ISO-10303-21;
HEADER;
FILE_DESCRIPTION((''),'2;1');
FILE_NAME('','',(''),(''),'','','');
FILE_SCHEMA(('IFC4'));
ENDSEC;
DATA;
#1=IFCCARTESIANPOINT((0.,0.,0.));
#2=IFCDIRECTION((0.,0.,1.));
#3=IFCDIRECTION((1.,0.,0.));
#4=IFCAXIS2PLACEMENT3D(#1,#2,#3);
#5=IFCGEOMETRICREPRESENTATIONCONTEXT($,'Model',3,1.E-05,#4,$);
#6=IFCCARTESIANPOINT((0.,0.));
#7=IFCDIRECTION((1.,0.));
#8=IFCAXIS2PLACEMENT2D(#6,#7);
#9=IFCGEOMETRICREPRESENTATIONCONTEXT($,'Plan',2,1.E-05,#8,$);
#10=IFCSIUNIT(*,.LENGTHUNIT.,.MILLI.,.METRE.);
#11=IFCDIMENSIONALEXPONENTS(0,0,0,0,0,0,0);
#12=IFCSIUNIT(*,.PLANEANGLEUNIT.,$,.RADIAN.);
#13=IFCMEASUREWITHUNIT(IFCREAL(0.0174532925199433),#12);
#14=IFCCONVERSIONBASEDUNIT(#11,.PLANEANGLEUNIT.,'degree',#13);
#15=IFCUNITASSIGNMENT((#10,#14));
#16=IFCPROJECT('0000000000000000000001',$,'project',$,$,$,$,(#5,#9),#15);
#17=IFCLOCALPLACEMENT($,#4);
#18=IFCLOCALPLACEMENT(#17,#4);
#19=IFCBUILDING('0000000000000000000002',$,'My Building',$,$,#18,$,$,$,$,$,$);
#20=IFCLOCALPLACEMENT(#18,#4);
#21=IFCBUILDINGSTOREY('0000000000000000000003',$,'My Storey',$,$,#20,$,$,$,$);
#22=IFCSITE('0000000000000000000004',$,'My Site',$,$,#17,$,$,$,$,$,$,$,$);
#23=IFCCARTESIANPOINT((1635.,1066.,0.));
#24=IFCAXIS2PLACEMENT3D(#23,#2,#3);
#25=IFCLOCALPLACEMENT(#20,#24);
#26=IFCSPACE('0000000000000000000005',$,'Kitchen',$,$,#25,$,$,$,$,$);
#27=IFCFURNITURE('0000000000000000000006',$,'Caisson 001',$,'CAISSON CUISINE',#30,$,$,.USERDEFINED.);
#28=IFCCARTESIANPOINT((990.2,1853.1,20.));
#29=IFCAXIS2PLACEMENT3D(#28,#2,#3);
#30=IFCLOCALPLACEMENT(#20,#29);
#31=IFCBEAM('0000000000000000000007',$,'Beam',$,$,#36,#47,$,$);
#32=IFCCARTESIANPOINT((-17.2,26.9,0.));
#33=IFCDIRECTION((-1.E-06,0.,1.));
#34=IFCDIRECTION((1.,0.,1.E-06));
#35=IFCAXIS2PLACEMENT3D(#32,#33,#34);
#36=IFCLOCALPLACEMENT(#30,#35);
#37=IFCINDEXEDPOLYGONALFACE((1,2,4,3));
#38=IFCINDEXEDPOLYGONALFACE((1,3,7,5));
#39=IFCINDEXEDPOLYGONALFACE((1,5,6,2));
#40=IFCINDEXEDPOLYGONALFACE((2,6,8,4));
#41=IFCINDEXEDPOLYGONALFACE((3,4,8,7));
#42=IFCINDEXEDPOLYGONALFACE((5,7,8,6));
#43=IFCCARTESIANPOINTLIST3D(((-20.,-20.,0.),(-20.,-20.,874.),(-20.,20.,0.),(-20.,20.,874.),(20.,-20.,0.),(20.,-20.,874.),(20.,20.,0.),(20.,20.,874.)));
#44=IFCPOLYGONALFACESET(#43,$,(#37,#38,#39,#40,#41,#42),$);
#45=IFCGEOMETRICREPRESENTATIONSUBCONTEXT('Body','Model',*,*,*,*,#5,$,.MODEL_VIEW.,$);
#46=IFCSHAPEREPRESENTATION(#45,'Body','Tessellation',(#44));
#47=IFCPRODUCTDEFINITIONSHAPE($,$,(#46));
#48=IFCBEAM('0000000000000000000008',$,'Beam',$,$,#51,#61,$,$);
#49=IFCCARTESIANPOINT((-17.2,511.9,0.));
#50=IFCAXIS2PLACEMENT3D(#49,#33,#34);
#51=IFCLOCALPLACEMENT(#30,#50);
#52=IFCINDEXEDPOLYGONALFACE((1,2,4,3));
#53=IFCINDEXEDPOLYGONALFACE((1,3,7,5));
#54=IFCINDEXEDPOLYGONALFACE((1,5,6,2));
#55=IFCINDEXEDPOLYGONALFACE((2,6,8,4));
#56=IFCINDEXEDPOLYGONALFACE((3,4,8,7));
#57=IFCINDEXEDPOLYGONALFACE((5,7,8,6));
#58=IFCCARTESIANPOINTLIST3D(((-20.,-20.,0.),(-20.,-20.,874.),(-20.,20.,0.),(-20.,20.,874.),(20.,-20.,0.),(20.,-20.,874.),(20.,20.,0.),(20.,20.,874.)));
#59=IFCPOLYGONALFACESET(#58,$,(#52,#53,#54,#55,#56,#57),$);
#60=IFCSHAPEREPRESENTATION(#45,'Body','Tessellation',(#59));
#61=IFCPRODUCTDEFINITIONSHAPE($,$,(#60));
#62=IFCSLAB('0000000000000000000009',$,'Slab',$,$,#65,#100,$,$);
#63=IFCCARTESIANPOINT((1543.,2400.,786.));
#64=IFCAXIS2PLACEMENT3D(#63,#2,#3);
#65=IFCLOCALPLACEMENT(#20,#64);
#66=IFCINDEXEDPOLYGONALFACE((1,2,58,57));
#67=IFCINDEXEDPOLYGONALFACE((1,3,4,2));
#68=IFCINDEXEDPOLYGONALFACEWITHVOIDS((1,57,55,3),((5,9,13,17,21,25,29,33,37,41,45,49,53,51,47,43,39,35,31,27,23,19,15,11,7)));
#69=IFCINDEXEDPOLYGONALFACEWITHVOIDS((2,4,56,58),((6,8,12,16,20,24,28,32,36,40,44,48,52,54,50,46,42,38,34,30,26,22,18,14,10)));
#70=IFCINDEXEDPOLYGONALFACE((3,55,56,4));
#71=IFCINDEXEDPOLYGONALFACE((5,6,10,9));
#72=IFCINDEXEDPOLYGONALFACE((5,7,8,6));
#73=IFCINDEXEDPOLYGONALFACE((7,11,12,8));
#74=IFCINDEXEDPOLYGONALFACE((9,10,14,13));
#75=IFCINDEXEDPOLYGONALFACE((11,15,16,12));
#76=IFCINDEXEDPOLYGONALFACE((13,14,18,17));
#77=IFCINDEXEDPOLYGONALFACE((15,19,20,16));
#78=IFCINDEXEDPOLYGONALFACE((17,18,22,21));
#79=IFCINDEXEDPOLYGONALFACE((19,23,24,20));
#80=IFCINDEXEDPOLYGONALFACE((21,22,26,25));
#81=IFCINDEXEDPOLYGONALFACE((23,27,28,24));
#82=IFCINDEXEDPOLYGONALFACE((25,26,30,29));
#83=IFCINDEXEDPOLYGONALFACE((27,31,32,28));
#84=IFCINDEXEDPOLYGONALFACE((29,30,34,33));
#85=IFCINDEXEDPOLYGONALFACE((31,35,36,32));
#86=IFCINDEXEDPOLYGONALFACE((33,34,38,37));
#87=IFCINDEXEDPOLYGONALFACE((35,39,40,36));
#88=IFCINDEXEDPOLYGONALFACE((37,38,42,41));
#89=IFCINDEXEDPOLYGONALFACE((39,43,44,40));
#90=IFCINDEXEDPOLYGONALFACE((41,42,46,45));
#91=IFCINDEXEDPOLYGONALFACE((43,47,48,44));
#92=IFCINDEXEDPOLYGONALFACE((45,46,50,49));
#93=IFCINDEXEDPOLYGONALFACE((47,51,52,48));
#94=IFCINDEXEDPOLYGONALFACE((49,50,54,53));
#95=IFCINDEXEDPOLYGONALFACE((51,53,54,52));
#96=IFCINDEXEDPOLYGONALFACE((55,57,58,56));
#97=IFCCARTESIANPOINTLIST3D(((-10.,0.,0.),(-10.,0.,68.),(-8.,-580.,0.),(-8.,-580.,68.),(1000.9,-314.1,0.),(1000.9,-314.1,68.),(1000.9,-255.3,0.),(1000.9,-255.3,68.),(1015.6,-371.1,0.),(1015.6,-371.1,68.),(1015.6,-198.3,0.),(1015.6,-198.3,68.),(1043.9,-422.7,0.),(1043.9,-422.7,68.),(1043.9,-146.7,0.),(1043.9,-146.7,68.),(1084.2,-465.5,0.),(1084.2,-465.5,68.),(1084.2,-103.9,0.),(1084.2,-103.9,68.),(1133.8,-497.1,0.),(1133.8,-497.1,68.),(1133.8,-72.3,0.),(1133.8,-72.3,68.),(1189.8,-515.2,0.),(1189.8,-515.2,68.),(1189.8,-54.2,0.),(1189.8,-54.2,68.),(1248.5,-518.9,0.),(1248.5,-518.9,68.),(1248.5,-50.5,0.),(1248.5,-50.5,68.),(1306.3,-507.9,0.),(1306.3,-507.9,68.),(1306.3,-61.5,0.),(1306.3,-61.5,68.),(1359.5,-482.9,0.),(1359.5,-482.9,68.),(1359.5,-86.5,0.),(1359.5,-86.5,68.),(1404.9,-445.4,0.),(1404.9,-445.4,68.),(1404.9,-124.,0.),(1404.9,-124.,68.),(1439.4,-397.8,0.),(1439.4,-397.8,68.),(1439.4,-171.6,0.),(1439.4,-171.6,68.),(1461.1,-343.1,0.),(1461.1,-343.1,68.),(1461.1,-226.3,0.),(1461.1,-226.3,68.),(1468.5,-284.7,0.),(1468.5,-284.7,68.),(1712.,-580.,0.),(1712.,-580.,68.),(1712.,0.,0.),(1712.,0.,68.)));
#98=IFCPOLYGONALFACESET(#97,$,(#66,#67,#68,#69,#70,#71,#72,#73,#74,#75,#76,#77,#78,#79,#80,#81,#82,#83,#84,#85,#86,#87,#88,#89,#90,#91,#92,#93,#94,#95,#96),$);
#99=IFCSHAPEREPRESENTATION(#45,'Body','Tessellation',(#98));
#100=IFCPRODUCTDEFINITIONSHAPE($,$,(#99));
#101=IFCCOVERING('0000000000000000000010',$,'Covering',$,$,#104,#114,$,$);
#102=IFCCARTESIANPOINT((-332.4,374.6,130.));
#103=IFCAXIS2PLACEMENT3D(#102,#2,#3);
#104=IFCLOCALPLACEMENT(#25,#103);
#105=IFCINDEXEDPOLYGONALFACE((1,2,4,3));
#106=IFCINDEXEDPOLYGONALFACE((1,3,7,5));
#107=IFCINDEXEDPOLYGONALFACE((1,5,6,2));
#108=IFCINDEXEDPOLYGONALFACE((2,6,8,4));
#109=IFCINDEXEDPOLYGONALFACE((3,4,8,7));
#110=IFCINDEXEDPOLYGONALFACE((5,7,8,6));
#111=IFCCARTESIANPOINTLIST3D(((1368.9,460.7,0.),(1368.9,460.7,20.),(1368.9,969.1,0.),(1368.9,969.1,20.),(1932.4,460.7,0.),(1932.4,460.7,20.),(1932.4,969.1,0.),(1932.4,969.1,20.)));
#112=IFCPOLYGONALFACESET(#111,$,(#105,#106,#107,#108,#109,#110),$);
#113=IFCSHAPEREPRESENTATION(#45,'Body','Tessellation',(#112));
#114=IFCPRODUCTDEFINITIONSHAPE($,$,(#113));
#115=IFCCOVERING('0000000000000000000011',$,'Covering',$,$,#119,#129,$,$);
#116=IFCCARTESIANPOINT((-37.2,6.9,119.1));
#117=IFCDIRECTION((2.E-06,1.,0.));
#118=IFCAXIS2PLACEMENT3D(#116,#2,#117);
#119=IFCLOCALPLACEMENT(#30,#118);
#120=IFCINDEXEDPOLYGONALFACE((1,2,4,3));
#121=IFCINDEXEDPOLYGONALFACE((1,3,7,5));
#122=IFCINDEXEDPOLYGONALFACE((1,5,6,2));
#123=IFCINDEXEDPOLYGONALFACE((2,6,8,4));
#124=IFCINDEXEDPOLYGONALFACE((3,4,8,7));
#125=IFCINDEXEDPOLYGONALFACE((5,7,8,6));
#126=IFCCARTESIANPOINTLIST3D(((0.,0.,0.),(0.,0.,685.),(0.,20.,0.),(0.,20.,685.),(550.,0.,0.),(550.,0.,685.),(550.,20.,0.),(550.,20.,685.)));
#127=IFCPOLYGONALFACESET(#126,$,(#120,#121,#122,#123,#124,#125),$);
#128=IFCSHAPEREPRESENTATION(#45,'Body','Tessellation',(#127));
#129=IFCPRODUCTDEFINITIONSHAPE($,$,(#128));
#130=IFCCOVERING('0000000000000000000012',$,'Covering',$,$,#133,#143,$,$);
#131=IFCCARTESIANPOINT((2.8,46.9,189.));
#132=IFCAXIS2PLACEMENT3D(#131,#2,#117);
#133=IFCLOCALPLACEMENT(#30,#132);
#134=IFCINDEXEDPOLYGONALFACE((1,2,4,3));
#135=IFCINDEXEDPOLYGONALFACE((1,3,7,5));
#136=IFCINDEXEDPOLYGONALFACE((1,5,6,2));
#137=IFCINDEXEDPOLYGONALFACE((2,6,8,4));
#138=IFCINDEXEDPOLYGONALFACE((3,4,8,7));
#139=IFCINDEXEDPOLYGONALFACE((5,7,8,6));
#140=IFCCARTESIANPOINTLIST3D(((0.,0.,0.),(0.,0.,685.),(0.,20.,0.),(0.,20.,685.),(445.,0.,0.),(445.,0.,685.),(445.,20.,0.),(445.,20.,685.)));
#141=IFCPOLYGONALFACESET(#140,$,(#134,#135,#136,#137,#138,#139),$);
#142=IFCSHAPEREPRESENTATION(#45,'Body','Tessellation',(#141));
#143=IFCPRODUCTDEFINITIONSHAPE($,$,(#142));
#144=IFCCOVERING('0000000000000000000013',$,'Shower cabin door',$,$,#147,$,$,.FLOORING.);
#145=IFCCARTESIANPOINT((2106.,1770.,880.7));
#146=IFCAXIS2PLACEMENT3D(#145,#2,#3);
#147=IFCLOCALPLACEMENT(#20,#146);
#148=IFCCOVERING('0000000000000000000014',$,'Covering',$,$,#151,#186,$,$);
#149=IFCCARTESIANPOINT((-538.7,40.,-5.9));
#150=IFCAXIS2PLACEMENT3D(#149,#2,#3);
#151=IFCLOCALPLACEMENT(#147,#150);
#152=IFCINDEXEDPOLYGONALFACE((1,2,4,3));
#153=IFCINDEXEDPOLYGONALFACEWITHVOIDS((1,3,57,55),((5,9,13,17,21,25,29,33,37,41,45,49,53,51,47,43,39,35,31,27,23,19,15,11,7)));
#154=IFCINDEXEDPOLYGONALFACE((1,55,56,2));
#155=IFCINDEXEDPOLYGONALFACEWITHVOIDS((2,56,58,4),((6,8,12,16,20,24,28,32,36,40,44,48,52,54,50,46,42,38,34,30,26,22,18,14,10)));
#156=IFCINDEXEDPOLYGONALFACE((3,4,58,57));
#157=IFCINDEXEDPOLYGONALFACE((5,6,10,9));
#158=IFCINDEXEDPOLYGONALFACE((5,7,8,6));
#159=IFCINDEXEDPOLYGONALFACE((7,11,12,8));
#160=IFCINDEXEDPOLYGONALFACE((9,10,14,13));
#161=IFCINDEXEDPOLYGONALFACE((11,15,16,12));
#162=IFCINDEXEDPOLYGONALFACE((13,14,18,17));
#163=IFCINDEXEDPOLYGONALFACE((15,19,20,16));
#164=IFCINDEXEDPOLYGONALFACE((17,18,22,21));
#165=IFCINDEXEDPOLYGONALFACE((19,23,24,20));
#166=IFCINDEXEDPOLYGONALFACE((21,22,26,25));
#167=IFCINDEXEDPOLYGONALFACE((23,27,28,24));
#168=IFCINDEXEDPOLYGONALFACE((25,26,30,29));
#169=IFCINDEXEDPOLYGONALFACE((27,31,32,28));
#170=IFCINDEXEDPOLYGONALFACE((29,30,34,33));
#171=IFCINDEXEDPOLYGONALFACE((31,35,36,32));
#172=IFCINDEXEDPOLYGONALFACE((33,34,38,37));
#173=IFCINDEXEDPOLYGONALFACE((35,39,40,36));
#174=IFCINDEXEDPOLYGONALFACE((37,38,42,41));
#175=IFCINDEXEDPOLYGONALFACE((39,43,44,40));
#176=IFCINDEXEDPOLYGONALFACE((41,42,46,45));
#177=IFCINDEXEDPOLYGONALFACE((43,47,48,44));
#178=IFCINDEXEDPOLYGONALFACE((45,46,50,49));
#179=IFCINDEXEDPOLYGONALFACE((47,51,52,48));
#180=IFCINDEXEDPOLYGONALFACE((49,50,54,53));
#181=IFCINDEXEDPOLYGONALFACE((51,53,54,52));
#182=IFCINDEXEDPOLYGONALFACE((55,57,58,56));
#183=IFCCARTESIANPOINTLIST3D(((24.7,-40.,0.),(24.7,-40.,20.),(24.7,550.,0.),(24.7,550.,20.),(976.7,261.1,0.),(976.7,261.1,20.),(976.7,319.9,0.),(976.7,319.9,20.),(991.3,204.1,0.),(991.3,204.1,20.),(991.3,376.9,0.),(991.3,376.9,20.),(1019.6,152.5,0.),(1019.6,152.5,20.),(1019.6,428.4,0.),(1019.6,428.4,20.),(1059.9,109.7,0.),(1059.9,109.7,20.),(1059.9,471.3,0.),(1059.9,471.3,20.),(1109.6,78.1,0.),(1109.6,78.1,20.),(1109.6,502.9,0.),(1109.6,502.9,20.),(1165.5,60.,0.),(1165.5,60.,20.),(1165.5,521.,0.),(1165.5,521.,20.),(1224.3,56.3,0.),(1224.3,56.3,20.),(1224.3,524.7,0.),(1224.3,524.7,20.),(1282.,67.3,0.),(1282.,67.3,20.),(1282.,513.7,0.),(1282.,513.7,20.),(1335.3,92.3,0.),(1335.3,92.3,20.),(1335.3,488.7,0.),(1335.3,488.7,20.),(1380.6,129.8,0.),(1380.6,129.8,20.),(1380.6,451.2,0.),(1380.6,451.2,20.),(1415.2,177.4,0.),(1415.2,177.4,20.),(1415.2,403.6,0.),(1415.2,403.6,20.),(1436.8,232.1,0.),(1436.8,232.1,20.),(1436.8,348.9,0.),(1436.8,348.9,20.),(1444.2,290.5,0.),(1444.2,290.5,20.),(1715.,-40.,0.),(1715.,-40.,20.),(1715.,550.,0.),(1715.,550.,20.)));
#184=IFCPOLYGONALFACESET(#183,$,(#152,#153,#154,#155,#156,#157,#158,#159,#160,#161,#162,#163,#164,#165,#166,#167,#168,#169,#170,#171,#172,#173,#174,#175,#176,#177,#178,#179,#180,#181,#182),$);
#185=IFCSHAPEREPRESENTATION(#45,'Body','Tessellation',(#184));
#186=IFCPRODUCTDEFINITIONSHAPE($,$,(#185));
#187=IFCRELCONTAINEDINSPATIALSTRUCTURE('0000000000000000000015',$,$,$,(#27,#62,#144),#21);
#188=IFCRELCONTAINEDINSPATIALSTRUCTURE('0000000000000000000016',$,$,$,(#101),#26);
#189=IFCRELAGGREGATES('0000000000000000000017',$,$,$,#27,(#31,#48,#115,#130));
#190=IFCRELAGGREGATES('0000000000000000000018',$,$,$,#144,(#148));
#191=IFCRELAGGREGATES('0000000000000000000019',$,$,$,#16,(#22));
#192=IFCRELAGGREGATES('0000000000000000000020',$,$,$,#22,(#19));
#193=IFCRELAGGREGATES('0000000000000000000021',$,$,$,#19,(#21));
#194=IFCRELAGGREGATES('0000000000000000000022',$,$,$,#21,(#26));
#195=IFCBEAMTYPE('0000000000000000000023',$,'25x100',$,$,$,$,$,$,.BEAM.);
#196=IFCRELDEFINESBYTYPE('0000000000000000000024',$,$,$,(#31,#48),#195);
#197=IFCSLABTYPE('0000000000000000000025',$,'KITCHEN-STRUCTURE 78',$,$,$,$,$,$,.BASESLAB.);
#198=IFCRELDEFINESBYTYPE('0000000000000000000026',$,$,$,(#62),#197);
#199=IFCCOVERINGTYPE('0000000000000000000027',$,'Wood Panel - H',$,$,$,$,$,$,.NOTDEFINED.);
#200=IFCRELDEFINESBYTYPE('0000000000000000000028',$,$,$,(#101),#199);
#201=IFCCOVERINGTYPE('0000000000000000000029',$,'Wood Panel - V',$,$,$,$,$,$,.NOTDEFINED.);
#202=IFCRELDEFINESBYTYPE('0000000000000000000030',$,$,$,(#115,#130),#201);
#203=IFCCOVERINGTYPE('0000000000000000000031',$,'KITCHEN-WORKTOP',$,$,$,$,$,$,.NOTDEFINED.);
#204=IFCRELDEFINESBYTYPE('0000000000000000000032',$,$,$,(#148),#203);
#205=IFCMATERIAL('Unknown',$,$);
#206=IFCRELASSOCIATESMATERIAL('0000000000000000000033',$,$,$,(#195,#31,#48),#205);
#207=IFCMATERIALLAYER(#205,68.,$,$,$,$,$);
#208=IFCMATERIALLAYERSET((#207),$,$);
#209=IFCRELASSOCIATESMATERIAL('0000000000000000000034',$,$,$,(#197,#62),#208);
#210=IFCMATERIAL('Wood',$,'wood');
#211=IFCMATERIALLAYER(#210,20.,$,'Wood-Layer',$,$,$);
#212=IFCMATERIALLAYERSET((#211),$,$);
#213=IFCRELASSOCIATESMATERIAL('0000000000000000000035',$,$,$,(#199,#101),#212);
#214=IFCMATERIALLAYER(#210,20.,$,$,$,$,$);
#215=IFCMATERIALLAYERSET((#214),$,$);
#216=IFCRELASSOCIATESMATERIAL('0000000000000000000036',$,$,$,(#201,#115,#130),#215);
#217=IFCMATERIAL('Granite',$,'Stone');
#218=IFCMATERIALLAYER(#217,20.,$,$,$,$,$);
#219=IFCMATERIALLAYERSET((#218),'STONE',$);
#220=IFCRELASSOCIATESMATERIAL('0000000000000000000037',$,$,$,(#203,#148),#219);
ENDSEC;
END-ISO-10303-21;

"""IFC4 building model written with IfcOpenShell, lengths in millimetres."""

from ifc_helpers import new_model, entity, si_unit, converted_unit, frame, frame_2d, origin_with_axes, origin_2d_with_axis, place, context, subcontext, project, spatial, indexed_curve, circle_curve, rectangle, outline, extrude, source, transform, mapped, material, layer, layer_set, layer_usage, material_profile, profile_set, profile_usage, type_object, element, aggregate, save


model = new_model("IFC4")

# Units and contexts
model_context = context("Model", 3, precision=1e-05, world=origin_with_axes())
plan_context = context("Plan", 2, precision=1e-05, world=origin_2d_with_axis())
body_context = subcontext(model_context, "Body", "Model", "MODEL_VIEW")
ifc_project = project(units=[si_unit("LENGTHUNIT", "METRE", prefix="MILLI"), converted_unit("PLANEANGLEUNIT", "degree", entity("IfcReal", 0.0174532925199433), si_unit("PLANEANGLEUNIT", "RADIAN"), dimensions=[0, 0, 0, 0, 0, 0, 0])], contexts=[model_context, plan_context])

# Site, building, storey, space
site_placement = place(None, origin_with_axes())
site = spatial("IfcSite", under=ifc_project, at=site_placement, Name="My Site")
building_placement = place(site_placement, origin_with_axes())
building = spatial("IfcBuilding", under=site, at=building_placement, Name="My Building")
storey_placement = place(building_placement, origin_with_axes())
storey = spatial("IfcBuildingStorey", under=building, at=storey_placement, Name="My Storey")
space_placement = place(storey_placement, frame((1635.0, 1066.0, 0.0), z_axis=(0.0, 0.0, 1.0), x_axis=(1.0, 0.0, 0.0)))
space = spatial("IfcSpace", under=storey, at=space_placement, Name="Kitchen")

# Shared definitions
ifc_material_1 = material(Name="Unknown")
ifc_material_profile_1 = material_profile(ifc_material_1, rectangle(XDim=40.0, YDim=40.0))
ifc_profile_set_1 = profile_set([ifc_material_profile_1])
beam_type = type_object("IfcBeamType", Name="25x100", PredefinedType="BEAM", material=ifc_profile_set_1)

# Furniture, beams
furniture_placement = place(storey_placement, frame((990.2, 1853.1, 20.0), z_axis=(0.0, 0.0, 1.0), x_axis=(1.0, 0.0, 0.0)))
furniture = element("IfcFurniture", 1, at=furniture_placement, inside=storey, Name="Caisson 001", ObjectType="CAISSON CUISINE", PredefinedType="USERDEFINED")
ifc_profile_usage_1 = profile_usage(ifc_profile_set_1)
beam_1_placement = place(furniture_placement, frame((-17.2, 26.9, 0.0), z_axis=(-0.000001, 0.0, 1.0), x_axis=(1.0, 0.0, 0.000001)))
beam_1 = element("IfcBeam", 2, at=beam_1_placement, type_object=beam_type, material=ifc_profile_usage_1, Name="Beam", context=body_context, shape_type="SweptSolid", body=[
    extrude(rectangle(XDim=40.0, YDim=40.0), origin_with_axes(), (0.0, 0.0, 1.0), 874.0),
])
ifc_profile_usage_2 = profile_usage(ifc_profile_set_1)
beam_2_placement = place(furniture_placement, frame((-17.2, 511.9, 0.0), z_axis=(-0.000001, 0.0, 1.0), x_axis=(1.0, 0.0, 0.000001)))
beam_2 = element("IfcBeam", 3, at=beam_2_placement, type_object=beam_type, material=ifc_profile_usage_2, Name="Beam", context=body_context, shape_type="SweptSolid", body=[
    extrude(rectangle(XDim=40.0, YDim=40.0), origin_with_axes(), (0.0, 0.0, 1.0), 874.0),
])

# Slab, opening
ifc_layer_1 = layer(ifc_material_1, 68.0)
ifc_layer_set_1 = layer_set([ifc_layer_1])
ifc_layer_usage_1 = layer_usage(ifc_layer_set_1, "AXIS3", "POSITIVE", 0.0)
slab_type = type_object("IfcSlabType", Name="KITCHEN-STRUCTURE 78", PredefinedType="BASESLAB", material=ifc_layer_set_1)
slab_placement = place(storey_placement, frame((1543.0, 2400.0, 786.0), z_axis=(0.0, 0.0, 1.0), x_axis=(1.0, 0.0, 0.0)))
slab = element("IfcSlab", 4, at=slab_placement, inside=storey, type_object=slab_type, material=ifc_layer_usage_1, Name="Slab", context=body_context, shape_type="SweptSolid", body=[
    extrude(outline(indexed_curve([(1712.0, -580.0), (1712.0, 0.0), (-10.0, 0.0), (-8.0, -580.0), (1712.0, -580.0)])), None, (0.0, 0.0, 1.0), 68.0),
])
shared_shape_1 = source(origin_with_axes(), body_context, "Body", "SweptSolid", [
    extrude(outline(circle_curve(frame_2d((159.7, 91.6)), 234.7)), frame((-0.2, -600.0, -0.1), z_axis=(0.0, -1.0, 0.0), x_axis=(1.0, 0.0, 0.0)), (0.0, 0.0, -1.0), 1200.0),
])
opening_1_placement = place(slab_placement, frame((1074.3, -193.2, -501.3), z_axis=(0.0, -1.0, 0.0), x_axis=(1.0, 0.0, 0.0)))
element("IfcOpeningElement", 5, at=opening_1_placement, cuts=slab, PredefinedType="OPENING", context=body_context, shape_type="MappedRepresentation", body=[
    mapped(shared_shape_1, transform((0.0, 0.0, 0.0), x_axis=(1.0, 0.0, 0.0), y_axis=(0.0, 1.0, 0.0), z_axis=(0.0, 0.0, 1.0), scale=1.0)),
])

# Covering
ifc_material_2 = material(Name="Wood", Category="wood")
ifc_layer_2 = layer(ifc_material_2, 20.0, Name="Wood-Layer")
ifc_layer_set_2 = layer_set([ifc_layer_2])
ifc_layer_usage_2 = layer_usage(ifc_layer_set_2, "AXIS3", "POSITIVE", 0.0)
covering_type_1 = type_object("IfcCoveringType", Name="Wood Panel - H", PredefinedType="NOTDEFINED", material=ifc_layer_set_2)
covering_1_placement = place(space_placement, frame((-332.4, 374.6, 130.0), z_axis=(0.0, 0.0, 1.0), x_axis=(1.0, 0.0, 0.0)))
element("IfcCovering", 6, at=covering_1_placement, inside=space, type_object=covering_type_1, material=ifc_layer_usage_2, Name="Covering", context=body_context, shape_type="SweptSolid", body=[
    extrude(outline(indexed_curve([(1932.4, 460.7), (1368.9, 460.7), (1368.9, 969.1), (1932.4, 969.1), (1932.4, 460.7)])), None, (0.0, 0.0, 1.0), 20.0),
])

# Coverings
ifc_layer_3 = layer(ifc_material_2, 20.0)
ifc_layer_set_3 = layer_set([ifc_layer_3])
ifc_layer_usage_3 = layer_usage(ifc_layer_set_3, "AXIS2", "POSITIVE", 0.0)
covering_type_2 = type_object("IfcCoveringType", Name="Wood Panel - V", PredefinedType="NOTDEFINED", material=ifc_layer_set_3)
covering_2_placement = place(furniture_placement, frame((-37.2, 6.9, 119.1), z_axis=(0.0, 0.0, 1.0), x_axis=(0.000002, 1.0, 0.0)))
covering_2 = element("IfcCovering", 7, at=covering_2_placement, type_object=covering_type_2, material=ifc_layer_usage_3, Name="Covering", context=body_context, shape_type="SweptSolid", body=[
    extrude(outline(indexed_curve([(0.0, 0.0), (0.0, 20.0), (550.0, 20.0), (550.0, 0.0), (0.0, 0.0)], self_intersect=False)), origin_with_axes(), (0.0, 0.0, 1.0), 685.0),
])
ifc_layer_usage_4 = layer_usage(ifc_layer_set_3, "AXIS2", "POSITIVE", 0.0)
covering_3_placement = place(furniture_placement, frame((2.8, 46.9, 189.0), z_axis=(0.0, 0.0, 1.0), x_axis=(0.000002, 1.0, 0.0)))
covering_3 = element("IfcCovering", 8, at=covering_3_placement, type_object=covering_type_2, material=ifc_layer_usage_4, Name="Covering", context=body_context, shape_type="SweptSolid", body=[
    extrude(outline(indexed_curve([(0.0, 0.0), (0.0, 20.0), (445.0, 20.0), (445.0, 0.0), (0.0, 0.0)], self_intersect=False)), origin_with_axes(), (0.0, 0.0, 1.0), 685.0),
])
aggregate(furniture, [beam_1, beam_2, covering_2, covering_3])

# Coverings, opening
covering_4_placement = place(storey_placement, frame((2106.0, 1770.0, 880.7), z_axis=(0.0, 0.0, 1.0), x_axis=(1.0, 0.0, 0.0)))
covering_4 = element("IfcCovering", 9, at=covering_4_placement, inside=storey, Name="Shower cabin door", PredefinedType="FLOORING")
ifc_material_3 = material(Name="Granite", Category="Stone")
ifc_layer_4 = layer(ifc_material_3, 20.0)
ifc_layer_set_4 = layer_set([ifc_layer_4], Name="STONE")
ifc_layer_usage_5 = layer_usage(ifc_layer_set_4, "AXIS3", "POSITIVE", 0.0)
covering_type_3 = type_object("IfcCoveringType", Name="KITCHEN-WORKTOP", PredefinedType="NOTDEFINED", material=ifc_layer_set_4)
covering_5_placement = place(covering_4_placement, frame((-538.7, 40.0, -5.9), z_axis=(0.0, 0.0, 1.0), x_axis=(1.0, 0.0, 0.0)))
covering_5 = element("IfcCovering", 10, at=covering_5_placement, type_object=covering_type_3, material=ifc_layer_usage_5, Name="Covering", context=body_context, shape_type="SolidModel", body=[
    extrude(outline(indexed_curve([(24.7, -40.0), (1715.0, -40.0), (1715.0, 550.0), (24.7, 550.0), (24.7, -40.0)])), None, (0.0, 0.0, 1.0), 20.0),
])
shared_shape_2 = source(origin_with_axes(), body_context, "Body", "SweptSolid", [
    extrude(outline(circle_curve(frame_2d((159.7, 91.6)), 234.7)), frame((-0.2, -600.0, -0.1), z_axis=(0.0, -1.0, 0.0), x_axis=(1.0, 0.0, 0.0)), (0.0, 0.0, -1.0), 1200.0),
])
opening_2_placement = place(covering_5_placement, frame((1050.1, 382.0, -570.0), z_axis=(0.0, -1.0, 0.0), x_axis=(1.0, 0.0, 0.0)))
element("IfcOpeningElement", 11, at=opening_2_placement, cuts=covering_5, PredefinedType="OPENING", context=body_context, shape_type="MappedRepresentation", body=[
    mapped(shared_shape_2, transform((0.0, 0.0, 0.0), x_axis=(1.0, 0.0, 0.0), y_axis=(0.0, 1.0, 0.0), z_axis=(0.0, 0.0, 1.0), scale=1.0)),
])
aggregate(covering_4, [covering_5])

save(model, "model.ifc")
